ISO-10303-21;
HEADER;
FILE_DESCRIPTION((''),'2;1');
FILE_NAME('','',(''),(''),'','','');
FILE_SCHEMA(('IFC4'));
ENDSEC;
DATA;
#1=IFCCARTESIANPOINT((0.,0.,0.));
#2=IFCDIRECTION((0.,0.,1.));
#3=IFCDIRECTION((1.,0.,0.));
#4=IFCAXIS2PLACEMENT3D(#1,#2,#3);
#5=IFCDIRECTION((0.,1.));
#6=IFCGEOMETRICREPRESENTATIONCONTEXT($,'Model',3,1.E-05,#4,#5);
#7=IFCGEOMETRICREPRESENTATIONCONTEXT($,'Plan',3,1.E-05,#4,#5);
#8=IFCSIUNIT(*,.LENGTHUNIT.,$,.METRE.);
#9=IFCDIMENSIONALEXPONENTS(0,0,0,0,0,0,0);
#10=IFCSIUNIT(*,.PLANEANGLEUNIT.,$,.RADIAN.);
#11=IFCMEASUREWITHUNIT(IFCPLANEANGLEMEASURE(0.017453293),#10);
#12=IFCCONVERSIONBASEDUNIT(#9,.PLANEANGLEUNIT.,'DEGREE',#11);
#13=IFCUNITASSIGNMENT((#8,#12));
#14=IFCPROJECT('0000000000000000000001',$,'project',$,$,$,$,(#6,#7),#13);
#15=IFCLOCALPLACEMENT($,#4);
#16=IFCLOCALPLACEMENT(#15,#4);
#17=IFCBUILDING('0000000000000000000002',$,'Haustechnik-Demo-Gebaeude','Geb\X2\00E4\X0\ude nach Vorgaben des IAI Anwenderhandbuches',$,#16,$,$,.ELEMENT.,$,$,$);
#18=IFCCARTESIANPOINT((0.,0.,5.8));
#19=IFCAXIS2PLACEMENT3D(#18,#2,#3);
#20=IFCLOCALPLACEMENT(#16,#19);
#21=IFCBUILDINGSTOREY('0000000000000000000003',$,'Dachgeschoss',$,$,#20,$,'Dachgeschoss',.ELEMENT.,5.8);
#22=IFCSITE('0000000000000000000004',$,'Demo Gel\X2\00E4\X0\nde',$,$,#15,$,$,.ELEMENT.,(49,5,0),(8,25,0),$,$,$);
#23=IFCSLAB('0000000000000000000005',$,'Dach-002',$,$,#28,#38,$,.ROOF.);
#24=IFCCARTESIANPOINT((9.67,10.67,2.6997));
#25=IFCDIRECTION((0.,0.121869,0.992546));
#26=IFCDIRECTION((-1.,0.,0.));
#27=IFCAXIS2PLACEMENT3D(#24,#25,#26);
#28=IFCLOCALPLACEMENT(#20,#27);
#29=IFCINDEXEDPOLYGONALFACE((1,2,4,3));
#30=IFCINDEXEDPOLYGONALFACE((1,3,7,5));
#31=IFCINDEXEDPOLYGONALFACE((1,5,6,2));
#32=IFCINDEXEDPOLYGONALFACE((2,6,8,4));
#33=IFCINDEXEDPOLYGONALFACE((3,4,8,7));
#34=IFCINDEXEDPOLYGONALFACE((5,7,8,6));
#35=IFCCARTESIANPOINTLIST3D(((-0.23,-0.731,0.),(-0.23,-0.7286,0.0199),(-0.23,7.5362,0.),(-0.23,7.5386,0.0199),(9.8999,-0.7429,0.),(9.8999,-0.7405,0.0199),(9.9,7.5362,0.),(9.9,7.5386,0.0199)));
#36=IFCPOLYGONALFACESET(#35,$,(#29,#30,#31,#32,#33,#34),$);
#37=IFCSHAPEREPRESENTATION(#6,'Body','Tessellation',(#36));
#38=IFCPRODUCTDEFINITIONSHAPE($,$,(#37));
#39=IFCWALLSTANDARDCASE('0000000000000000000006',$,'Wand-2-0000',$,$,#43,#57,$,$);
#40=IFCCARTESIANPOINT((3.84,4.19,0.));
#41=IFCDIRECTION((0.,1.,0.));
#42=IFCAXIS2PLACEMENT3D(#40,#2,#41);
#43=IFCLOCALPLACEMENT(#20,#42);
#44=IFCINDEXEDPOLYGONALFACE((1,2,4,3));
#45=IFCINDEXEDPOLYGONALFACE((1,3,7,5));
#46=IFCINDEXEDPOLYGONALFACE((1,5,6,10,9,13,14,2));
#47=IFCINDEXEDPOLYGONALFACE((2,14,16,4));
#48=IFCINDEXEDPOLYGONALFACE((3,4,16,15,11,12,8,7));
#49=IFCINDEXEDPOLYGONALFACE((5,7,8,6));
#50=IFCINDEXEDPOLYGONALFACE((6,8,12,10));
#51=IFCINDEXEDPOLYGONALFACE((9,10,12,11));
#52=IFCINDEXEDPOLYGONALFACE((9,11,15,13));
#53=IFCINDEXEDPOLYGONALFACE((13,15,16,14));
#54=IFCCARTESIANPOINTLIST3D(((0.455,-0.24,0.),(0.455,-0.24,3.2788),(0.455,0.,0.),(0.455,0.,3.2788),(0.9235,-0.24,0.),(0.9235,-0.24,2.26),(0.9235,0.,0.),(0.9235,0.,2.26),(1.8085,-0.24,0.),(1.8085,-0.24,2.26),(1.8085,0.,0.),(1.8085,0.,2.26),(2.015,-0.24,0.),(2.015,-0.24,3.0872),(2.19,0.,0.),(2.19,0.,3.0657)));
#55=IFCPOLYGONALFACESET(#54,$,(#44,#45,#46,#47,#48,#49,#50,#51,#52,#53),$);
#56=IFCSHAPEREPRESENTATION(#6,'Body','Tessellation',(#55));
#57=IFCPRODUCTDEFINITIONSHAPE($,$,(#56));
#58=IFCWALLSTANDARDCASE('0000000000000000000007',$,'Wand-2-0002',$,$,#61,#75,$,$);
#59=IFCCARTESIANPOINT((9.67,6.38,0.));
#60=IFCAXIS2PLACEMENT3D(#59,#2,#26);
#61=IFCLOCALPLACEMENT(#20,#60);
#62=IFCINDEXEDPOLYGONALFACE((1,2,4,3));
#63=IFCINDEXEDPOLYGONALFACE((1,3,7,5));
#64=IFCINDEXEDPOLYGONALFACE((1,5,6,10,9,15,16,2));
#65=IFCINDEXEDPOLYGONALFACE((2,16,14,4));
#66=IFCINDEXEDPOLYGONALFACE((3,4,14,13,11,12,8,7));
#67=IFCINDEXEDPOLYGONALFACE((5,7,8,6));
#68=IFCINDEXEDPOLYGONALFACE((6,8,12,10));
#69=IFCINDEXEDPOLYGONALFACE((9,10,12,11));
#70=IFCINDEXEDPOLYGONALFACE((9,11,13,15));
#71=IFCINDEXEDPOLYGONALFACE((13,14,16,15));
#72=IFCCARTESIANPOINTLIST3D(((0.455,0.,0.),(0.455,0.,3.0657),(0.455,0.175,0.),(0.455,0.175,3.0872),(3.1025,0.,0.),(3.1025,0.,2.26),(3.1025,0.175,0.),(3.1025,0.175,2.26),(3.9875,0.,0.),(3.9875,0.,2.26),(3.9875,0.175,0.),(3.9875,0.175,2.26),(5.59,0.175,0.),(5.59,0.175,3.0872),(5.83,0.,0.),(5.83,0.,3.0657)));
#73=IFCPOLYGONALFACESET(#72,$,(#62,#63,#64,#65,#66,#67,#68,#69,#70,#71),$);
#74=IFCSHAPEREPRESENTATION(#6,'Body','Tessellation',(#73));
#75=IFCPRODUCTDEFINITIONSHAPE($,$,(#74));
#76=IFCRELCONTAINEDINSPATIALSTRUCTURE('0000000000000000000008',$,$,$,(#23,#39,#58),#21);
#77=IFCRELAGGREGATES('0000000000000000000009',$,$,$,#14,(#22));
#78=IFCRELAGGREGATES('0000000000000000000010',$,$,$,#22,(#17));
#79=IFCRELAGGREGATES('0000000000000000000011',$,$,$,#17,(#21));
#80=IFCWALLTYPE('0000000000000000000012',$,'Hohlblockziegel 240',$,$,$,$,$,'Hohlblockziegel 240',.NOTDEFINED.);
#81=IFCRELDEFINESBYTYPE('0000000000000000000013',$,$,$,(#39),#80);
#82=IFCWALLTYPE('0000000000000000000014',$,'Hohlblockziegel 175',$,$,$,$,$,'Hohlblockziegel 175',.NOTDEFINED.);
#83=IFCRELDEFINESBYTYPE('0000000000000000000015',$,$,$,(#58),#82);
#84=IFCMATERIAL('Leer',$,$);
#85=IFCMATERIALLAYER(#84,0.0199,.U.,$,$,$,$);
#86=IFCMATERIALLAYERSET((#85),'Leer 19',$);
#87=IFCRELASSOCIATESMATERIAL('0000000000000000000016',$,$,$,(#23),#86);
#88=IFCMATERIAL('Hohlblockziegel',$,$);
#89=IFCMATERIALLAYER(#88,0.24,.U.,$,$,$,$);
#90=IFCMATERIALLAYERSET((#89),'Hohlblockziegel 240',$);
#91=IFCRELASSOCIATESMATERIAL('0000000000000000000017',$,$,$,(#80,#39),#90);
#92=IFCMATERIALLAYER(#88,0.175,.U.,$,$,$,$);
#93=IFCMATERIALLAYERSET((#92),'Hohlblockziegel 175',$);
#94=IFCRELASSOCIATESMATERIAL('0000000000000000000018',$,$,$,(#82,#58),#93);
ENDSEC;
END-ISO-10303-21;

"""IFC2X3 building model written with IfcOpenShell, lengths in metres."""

from ifc_helpers import new_model, entity, si_unit, converted_unit, direction, frame, frame_2d, origin_with_axes, place, context, project, spatial, polyline, rectangle, outline, extrude, clip, halfspace, material, layer, layer_set, layer_usage, type_object, element, save


model = new_model("IFC2X3")

# Units and contexts
model_context = context("Model", 3, precision=1e-05, world=origin_with_axes(), true_north=direction((0.0, 1.0)))
plan_context = context("Plan", 3, precision=1e-05, world=origin_with_axes(), true_north=direction((0.0, 1.0)))
ifc_project = project(units=[si_unit("LENGTHUNIT", "METRE"), converted_unit("PLANEANGLEUNIT", "DEGREE", entity("IfcPlaneAngleMeasure", 0.017453293), si_unit("PLANEANGLEUNIT", "RADIAN"), dimensions=[0, 0, 0, 0, 0, 0, 0])], contexts=[model_context, plan_context])

# Site, building, storey
site_placement = place(None, origin_with_axes())
site = spatial("IfcSite", under=ifc_project, at=site_placement, Name="Demo Gelände", CompositionType="ELEMENT", RefLatitude=(49, 5, 0), RefLongitude=(8, 25, 0))
building_placement = place(site_placement, origin_with_axes())
building = spatial("IfcBuilding", under=site, at=building_placement, Name="Haustechnik-Demo-Gebaeude", Description="Gebäude nach Vorgaben des IAI Anwenderhandbuches", CompositionType="ELEMENT")
storey_placement = place(building_placement, frame((0.0, 0.0, 5.8), z_axis=(0.0, 0.0, 1.0), x_axis=(1.0, 0.0, 0.0)))
storey = spatial("IfcBuildingStorey", under=building, at=storey_placement, Name="Dachgeschoss", LongName="Dachgeschoss", CompositionType="ELEMENT", Elevation=5.8)

# Slab
ifc_material_1 = material(Name="Leer")
ifc_layer_1 = layer(ifc_material_1, 0.0199, ventilated="UNKNOWN")
ifc_layer_set_1 = layer_set([ifc_layer_1], Name="Leer 19")
ifc_layer_usage_1 = layer_usage(ifc_layer_set_1, "AXIS3", "NEGATIVE", 0.0199)
slab_1_placement = place(storey_placement, frame((9.67, 10.67, 2.6997), z_axis=(0.0, 0.121869, 0.992546), x_axis=(-1.0, 0.0, 0.0)))
element("IfcSlab", 1, at=slab_1_placement, inside=storey, material=ifc_layer_usage_1, Name="Dach-002", PredefinedType="ROOF", context=model_context, shape_type="SweptSolid", body=[
    extrude(outline(polyline([(9.8999, -0.7429), (9.9, 7.5362), (-0.23, 7.5362), (-0.23, -0.731), (9.8999, -0.7429)])), origin_with_axes(), (0.0, 0.121869, 0.992546), 0.02),
])

# Walls, openings
ifc_material_2 = material(Name="Hohlblockziegel")
ifc_layer_2 = layer(ifc_material_2, 0.24, ventilated="UNKNOWN")
ifc_layer_set_2 = layer_set([ifc_layer_2], Name="Hohlblockziegel 240")
ifc_layer_usage_2 = layer_usage(ifc_layer_set_2, "AXIS2", "NEGATIVE", 0.0)
wall_type_1 = type_object("IfcWallType", Name="Hohlblockziegel 240", ElementType="Hohlblockziegel 240", PredefinedType="NOTDEFINED", material=ifc_layer_set_2)
wall_1_placement = place(storey_placement, frame((3.84, 4.19, 0.0), z_axis=(0.0, 0.0, 1.0), x_axis=(0.0, 1.0, 0.0)))
wall_1 = element("IfcWallStandardCase", 2, at=wall_1_placement, inside=storey, type_object=wall_type_1, material=ifc_layer_usage_2, Name="Wand-2-0000", context=model_context, shape_type="Clipping", body=[
    clip(clip(extrude(outline(polyline([(0.455, -0.24), (2.015, -0.24), (2.19, 0.0), (0.455, 0.0), (0.455, -0.24)])), origin_with_axes(), (0.0, 0.0, 1.0), 4.0), halfspace(frame((0.4034, 0.0, 3.2851), z_axis=(0.121869, 0.0, 0.992546), x_axis=(0.0, 1.0, 0.0)), False)), halfspace(frame((0.4228, 0.0, 3.4434), z_axis=(0.121869, 0.0, 0.992546), x_axis=(0.0, 1.0, 0.0)), False)),
])
opening_1_placement = place(wall_1_placement, frame((1.366, -0.24, 0.0), z_axis=(0.0, 0.0, 1.0), x_axis=(1.0, 0.0, 0.0)))
element("IfcOpeningElement", 3, at=opening_1_placement, cuts=wall_1, ObjectType="Opening", context=model_context, shape_type="SweptSolid", body=[
    extrude(rectangle(XDim=0.885, YDim=2.26, at=frame_2d((0.0, 1.13), x_axis=(-1.0, 0.0))), frame((0.0, 0.0, 0.0), z_axis=(0.0, 1.0, 0.0), x_axis=(-1.0, 0.0, 0.0)), (0.0, 0.0, 1.0), 0.24),
])
ifc_layer_3 = layer(ifc_material_2, 0.175, ventilated="UNKNOWN")
ifc_layer_set_3 = layer_set([ifc_layer_3], Name="Hohlblockziegel 175")
ifc_layer_usage_3 = layer_usage(ifc_layer_set_3, "AXIS2", "POSITIVE", 0.0)
wall_type_2 = type_object("IfcWallType", Name="Hohlblockziegel 175", ElementType="Hohlblockziegel 175", PredefinedType="NOTDEFINED", material=ifc_layer_set_3)
wall_2_placement = place(storey_placement, frame((9.67, 6.38, 0.0), z_axis=(0.0, 0.0, 1.0), x_axis=(-1.0, 0.0, 0.0)))
wall_2 = element("IfcWallStandardCase", 4, at=wall_2_placement, inside=storey, type_object=wall_type_2, material=ifc_layer_usage_3, Name="Wand-2-0002", context=model_context, shape_type="Clipping", body=[
    clip(clip(extrude(outline(polyline([(0.455, 0.0), (5.83, 0.0), (5.59, 0.175), (0.455, 0.175), (0.455, 0.0)])), origin_with_axes(), (0.0, 0.0, 1.0), 4.0), halfspace(frame((0.0, -0.3708, 3.0202), z_axis=(0.0, -0.121869, 0.992546), x_axis=(0.0, 0.992546, 0.121869)), False)), halfspace(frame((0.0, -0.3903, 3.1785), z_axis=(0.0, -0.121869, 0.992546), x_axis=(0.0, 0.992546, 0.121869)), False)),
])
opening_2_placement = place(wall_2_placement, frame((3.545, 0.0, 0.0), z_axis=(0.0, 0.0, 1.0), x_axis=(1.0, 0.0, 0.0)))
element("IfcOpeningElement", 5, at=opening_2_placement, cuts=wall_2, ObjectType="Opening", context=model_context, shape_type="SweptSolid", body=[
    extrude(rectangle(XDim=0.885, YDim=2.26, at=frame_2d((0.0, 1.13), x_axis=(-1.0, 0.0))), frame((0.0, 0.0, 0.0), z_axis=(0.0, 1.0, 0.0), x_axis=(-1.0, 0.0, 0.0)), (0.0, 0.0, 1.0), 0.175),
])

save(model, "model.ifc")
